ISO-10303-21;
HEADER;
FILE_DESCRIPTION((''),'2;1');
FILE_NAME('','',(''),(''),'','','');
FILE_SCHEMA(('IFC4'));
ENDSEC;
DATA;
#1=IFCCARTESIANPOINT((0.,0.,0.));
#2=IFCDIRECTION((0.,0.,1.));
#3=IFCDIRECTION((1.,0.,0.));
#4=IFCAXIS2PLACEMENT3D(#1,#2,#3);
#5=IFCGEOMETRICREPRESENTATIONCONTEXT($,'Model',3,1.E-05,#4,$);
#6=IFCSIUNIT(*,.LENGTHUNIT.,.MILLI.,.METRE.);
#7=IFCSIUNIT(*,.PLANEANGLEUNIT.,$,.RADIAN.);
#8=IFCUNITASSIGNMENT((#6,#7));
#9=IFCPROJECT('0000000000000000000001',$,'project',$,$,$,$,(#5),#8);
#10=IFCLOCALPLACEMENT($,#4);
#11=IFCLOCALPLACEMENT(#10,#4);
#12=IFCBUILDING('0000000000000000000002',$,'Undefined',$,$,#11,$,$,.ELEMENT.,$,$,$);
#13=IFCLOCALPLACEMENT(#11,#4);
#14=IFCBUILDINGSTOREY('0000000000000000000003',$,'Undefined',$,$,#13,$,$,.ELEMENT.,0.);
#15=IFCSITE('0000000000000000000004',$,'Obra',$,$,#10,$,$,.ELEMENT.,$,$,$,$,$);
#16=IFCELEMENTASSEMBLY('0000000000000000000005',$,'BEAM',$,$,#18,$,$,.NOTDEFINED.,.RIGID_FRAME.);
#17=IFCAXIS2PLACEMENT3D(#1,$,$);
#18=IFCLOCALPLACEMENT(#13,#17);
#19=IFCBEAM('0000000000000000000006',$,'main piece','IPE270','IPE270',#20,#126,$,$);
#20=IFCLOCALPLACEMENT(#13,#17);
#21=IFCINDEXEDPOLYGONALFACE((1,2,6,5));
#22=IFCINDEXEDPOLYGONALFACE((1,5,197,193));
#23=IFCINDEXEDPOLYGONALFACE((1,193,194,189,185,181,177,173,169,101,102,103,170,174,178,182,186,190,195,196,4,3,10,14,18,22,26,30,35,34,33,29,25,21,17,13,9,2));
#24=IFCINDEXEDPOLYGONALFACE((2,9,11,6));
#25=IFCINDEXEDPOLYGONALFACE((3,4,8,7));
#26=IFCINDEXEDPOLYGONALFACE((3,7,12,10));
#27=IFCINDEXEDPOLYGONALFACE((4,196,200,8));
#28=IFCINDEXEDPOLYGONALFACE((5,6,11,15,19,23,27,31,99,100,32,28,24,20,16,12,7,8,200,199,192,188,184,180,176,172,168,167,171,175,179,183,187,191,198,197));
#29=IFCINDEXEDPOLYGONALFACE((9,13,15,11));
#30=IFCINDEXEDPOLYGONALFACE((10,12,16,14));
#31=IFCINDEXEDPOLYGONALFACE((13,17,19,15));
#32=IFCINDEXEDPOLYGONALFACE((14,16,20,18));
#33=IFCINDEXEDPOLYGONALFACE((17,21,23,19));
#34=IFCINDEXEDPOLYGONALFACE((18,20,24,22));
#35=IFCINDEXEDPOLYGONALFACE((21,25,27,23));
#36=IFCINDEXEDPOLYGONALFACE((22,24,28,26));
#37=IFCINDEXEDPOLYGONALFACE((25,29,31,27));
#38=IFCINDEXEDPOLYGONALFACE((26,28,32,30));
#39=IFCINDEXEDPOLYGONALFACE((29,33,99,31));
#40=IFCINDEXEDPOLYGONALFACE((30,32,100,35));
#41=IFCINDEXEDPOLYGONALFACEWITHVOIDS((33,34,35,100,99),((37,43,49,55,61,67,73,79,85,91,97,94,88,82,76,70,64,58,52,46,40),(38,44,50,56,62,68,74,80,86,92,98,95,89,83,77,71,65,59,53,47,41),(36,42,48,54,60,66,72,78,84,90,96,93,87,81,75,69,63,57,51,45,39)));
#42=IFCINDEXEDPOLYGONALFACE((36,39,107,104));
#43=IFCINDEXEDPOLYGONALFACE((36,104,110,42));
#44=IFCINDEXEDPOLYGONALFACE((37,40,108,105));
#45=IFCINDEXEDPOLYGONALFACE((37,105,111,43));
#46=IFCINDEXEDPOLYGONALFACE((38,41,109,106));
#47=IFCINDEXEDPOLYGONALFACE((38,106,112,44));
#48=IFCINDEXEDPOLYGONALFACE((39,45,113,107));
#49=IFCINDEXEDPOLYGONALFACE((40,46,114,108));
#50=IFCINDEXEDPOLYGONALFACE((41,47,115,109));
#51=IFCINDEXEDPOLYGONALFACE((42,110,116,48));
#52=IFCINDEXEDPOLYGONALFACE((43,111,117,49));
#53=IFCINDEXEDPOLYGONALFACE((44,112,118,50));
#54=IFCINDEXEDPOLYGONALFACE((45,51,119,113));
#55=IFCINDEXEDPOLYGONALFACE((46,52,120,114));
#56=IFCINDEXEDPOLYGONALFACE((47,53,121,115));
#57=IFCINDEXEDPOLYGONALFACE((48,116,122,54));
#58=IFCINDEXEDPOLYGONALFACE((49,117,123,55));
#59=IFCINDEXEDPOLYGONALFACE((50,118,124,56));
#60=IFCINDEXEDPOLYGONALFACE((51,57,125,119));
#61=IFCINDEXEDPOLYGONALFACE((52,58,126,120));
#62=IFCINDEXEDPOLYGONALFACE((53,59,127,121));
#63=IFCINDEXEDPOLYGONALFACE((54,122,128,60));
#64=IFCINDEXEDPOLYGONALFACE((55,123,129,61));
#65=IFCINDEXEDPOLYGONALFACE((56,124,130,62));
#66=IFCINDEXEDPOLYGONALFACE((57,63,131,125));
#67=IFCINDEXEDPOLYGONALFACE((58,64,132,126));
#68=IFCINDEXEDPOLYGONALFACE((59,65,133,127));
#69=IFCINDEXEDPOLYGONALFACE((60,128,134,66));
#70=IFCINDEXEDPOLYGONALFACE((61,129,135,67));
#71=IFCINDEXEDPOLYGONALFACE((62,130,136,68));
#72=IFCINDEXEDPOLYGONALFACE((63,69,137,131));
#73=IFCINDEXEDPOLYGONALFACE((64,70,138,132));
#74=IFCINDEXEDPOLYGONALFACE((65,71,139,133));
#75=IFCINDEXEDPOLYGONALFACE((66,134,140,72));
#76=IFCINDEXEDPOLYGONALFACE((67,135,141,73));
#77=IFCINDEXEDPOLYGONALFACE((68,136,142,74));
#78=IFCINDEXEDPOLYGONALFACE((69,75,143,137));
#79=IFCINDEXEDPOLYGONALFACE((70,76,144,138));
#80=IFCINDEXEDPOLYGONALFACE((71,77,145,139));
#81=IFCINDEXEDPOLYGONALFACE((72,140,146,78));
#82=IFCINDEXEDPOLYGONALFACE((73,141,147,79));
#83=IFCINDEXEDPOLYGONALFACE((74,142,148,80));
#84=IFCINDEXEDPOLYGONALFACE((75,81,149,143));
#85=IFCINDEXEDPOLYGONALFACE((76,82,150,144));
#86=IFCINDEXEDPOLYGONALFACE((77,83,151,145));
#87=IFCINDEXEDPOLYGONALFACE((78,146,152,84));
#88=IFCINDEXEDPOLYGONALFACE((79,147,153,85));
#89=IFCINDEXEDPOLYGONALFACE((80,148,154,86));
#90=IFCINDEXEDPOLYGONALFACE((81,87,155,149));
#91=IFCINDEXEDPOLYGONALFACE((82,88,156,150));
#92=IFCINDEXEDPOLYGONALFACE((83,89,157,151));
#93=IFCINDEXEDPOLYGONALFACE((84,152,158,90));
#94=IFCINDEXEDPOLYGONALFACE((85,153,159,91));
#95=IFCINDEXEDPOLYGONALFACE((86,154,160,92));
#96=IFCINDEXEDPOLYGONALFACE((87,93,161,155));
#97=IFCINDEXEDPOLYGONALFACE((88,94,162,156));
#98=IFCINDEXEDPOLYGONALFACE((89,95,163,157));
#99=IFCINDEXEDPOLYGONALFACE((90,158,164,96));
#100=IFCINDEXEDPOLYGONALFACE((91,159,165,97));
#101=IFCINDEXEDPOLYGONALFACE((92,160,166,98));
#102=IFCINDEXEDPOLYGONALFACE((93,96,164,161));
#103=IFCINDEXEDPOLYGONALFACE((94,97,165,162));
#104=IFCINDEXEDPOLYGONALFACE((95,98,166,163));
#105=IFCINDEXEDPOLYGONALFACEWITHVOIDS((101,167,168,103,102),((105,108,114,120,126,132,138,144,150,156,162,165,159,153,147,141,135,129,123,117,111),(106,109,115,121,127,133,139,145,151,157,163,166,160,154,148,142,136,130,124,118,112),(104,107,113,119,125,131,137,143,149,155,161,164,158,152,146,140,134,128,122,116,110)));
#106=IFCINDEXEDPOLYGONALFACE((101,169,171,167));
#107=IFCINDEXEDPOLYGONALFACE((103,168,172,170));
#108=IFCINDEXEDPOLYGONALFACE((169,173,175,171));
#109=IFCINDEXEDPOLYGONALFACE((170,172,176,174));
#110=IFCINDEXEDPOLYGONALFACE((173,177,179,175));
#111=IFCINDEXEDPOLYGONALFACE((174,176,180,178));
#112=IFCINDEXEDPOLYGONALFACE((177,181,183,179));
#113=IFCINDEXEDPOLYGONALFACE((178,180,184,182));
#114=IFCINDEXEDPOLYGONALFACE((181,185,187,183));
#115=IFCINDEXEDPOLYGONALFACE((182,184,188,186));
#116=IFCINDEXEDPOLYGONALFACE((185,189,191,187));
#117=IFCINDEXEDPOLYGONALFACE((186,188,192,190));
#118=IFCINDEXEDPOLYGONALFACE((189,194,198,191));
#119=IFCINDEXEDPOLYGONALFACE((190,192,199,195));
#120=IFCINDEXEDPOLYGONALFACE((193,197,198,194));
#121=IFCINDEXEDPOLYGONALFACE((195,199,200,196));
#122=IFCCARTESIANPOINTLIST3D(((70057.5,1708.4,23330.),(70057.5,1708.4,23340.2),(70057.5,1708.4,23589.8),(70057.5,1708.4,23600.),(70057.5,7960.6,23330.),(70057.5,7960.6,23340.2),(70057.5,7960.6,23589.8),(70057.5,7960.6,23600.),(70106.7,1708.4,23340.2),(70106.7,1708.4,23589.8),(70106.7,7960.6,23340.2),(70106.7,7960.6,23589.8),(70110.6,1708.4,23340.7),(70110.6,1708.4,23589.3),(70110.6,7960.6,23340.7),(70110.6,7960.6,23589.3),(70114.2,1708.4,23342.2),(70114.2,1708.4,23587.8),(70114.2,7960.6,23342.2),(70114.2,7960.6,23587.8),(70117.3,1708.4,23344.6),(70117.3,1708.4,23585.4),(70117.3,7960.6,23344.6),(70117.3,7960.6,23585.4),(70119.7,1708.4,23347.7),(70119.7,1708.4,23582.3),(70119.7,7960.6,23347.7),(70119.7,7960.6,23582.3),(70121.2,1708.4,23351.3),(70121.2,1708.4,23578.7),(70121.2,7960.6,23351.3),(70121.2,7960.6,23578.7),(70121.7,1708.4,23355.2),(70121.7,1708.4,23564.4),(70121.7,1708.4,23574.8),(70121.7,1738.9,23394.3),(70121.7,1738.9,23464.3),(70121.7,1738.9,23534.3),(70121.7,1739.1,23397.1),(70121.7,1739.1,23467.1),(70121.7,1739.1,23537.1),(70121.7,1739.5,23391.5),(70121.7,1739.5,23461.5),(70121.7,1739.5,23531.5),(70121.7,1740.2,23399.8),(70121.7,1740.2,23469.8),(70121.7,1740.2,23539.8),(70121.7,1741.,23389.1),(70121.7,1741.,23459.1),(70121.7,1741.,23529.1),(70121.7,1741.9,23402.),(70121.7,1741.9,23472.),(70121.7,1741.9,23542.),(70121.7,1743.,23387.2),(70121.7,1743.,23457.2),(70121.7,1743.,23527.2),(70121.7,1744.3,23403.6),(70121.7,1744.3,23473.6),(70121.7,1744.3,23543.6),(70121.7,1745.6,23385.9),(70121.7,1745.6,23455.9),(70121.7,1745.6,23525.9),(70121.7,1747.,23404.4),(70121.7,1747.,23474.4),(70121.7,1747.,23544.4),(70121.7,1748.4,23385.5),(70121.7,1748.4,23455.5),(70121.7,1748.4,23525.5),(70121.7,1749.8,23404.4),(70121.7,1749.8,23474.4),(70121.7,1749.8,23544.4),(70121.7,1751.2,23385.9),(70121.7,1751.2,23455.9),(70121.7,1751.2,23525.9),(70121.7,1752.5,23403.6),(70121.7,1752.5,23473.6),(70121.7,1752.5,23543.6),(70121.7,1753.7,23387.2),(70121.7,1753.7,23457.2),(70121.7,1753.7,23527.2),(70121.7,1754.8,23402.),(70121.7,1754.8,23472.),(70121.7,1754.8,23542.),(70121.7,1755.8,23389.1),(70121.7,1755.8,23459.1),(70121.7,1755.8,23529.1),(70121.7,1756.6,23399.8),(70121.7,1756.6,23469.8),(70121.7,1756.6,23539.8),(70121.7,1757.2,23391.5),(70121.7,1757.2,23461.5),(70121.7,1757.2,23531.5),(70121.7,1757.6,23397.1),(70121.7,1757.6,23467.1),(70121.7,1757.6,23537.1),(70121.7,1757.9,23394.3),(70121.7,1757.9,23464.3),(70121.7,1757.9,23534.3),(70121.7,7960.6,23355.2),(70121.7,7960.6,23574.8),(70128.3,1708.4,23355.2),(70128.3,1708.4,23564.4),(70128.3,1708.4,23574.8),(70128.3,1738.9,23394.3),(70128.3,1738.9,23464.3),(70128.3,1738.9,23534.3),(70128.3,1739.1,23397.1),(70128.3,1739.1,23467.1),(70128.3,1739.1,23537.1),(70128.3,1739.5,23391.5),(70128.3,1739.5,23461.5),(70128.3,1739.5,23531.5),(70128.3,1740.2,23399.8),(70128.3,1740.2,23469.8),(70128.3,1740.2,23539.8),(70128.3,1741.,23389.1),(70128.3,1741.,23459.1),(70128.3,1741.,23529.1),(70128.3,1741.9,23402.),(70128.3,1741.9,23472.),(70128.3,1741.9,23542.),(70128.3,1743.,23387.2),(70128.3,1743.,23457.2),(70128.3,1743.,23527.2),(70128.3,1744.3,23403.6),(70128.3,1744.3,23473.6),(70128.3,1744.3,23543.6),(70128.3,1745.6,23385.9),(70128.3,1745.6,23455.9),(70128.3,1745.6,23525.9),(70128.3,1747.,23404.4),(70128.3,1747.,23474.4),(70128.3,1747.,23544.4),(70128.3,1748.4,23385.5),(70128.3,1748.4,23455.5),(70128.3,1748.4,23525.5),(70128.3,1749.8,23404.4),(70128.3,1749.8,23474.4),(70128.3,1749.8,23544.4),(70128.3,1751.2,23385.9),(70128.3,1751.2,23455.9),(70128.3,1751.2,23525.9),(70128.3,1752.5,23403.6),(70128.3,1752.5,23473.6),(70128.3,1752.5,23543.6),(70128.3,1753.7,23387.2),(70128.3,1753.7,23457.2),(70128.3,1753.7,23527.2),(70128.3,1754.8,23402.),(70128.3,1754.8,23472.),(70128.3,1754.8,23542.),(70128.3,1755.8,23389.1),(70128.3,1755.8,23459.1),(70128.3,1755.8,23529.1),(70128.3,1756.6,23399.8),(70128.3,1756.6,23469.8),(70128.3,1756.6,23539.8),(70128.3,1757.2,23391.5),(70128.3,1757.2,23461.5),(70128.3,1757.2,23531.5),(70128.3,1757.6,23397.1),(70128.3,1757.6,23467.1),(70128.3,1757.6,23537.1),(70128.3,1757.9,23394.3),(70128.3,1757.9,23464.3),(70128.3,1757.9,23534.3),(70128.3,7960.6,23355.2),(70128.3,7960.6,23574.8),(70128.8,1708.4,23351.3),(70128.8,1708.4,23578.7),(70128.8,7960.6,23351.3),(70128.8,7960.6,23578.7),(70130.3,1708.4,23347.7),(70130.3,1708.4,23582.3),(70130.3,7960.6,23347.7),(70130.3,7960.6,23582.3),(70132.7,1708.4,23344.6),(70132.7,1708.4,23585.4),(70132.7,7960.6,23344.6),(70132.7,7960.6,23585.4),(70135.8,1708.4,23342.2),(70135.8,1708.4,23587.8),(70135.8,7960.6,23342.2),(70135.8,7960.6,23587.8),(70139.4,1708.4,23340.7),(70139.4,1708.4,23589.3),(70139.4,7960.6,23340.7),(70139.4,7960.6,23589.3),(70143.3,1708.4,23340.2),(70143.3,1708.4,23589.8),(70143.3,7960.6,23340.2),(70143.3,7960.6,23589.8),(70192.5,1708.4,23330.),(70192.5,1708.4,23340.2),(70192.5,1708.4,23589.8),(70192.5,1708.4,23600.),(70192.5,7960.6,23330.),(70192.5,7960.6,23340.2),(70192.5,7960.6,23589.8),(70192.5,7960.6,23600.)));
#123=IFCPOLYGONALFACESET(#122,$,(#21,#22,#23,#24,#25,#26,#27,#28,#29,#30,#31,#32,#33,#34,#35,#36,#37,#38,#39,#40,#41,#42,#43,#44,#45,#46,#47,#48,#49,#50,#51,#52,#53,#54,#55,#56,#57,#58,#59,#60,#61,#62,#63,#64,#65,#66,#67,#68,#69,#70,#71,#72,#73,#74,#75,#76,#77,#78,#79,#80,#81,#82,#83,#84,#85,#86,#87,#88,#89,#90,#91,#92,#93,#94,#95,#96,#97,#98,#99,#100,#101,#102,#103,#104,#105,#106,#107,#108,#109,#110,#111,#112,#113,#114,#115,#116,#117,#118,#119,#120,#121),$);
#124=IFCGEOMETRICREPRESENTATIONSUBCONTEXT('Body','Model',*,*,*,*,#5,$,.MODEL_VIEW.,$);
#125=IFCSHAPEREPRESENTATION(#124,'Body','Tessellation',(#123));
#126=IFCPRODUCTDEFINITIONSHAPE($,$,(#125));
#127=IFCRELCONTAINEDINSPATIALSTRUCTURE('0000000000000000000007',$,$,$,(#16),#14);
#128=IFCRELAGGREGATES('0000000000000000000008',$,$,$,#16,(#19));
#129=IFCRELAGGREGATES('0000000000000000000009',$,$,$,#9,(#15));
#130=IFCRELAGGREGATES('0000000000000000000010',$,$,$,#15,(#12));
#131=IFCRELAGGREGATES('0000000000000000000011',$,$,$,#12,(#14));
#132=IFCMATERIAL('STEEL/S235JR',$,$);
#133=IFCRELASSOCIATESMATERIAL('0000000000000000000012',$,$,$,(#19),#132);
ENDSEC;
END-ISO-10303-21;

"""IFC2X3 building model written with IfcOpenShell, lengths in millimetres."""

from ifc_helpers import new_model, si_unit, frame, origin_with_axes, origin_2d_with_axis, place, context, subcontext, project, spatial, rectangle, circle, i_section, extrude, clip, halfspace, source, transform, mapped, material, element, aggregate, save


model = new_model("IFC2X3")

# Units and contexts
model_context = context("Model", 3, precision=1e-05, world=origin_with_axes())
body_context = subcontext(model_context, "Body", "Model", "MODEL_VIEW")
ifc_project = project(units=[si_unit("LENGTHUNIT", "METRE", prefix="MILLI"), si_unit("PLANEANGLEUNIT", "RADIAN")], contexts=[model_context])

# Site, building, storey
site_placement = place(None, origin_with_axes())
site = spatial("IfcSite", under=ifc_project, at=site_placement, Name="Obra", CompositionType="ELEMENT")
building_placement = place(site_placement, origin_with_axes())
building = spatial("IfcBuilding", under=site, at=building_placement, Name="Undefined", CompositionType="ELEMENT")
storey_placement = place(building_placement, origin_with_axes())
storey = spatial("IfcBuildingStorey", under=building, at=storey_placement, Name="Undefined", CompositionType="ELEMENT", Elevation=0.0)

# Element assembly, beam, openings
ifc_material_1 = material(Name="STEEL/S235JR")
shared_shape_1 = source(origin_with_axes(), body_context, "Body", "SweptSolid", [
    extrude(circle(Radius=9.5, at=origin_2d_with_axis()), frame((0.0, -3.4, 0.0), z_axis=(0.0, 1.0, 0.0), x_axis=(1.0, 0.0, 0.0)), (0.0, 0.0, 1.0), 6.8),
])
assembly_1_placement = place(storey_placement, origin_with_axes())
assembly_1 = element("IfcElementAssembly", 1, at=assembly_1_placement, inside=storey, Name="BEAM", AssemblyPlace="NOTDEFINED", PredefinedType="RIGID_FRAME")
beam_1_placement = place(assembly_1_placement, frame((70125.0, 1711.1, 23465.0), z_axis=(0.0, 0.0, 1.0), x_axis=(0.0, 1.0, 0.0)))
beam_1 = element("IfcBeam", 2, at=beam_1_placement, material=ifc_material_1, Name="main piece", Description="IPE270", ObjectType="IPE270", context=body_context, shape_type="Clipping", body=[
    clip(clip(extrude(i_section(OverallWidth=135.0, OverallDepth=270.0, WebThickness=6.6, FlangeThickness=10.2, FilletRadius=15.0, at=origin_2d_with_axis()), frame((6296.4, 0.0, 0.0), z_axis=(-1.0, 0.0, 0.0), x_axis=(0.0, -1.0, 0.0)), (0.0, 0.0, 1.0), 6299.1), halfspace(frame((6249.5, -60.0, -120.0), z_axis=(1.0, 0.0, 0.0), x_axis=(0.0, 0.0, 1.0)), False)), halfspace(frame((-2.7, 0.0, -235.0), z_axis=(1.0, 0.0, 0.0), x_axis=(0.0, -1.0, 0.0)), True)),
])
opening_1_placement = place(assembly_1_placement, frame((70125.0, 1711.1, 23465.0), z_axis=(0.0, 0.0, 1.0), x_axis=(0.0, 1.0, 0.0)))
element("IfcOpeningElement", 3, at=opening_1_placement, cuts=beam_1, ObjectType="Recess", context=body_context, shape_type="SweptSolid", body=[
    extrude(rectangle(XDim=36.6, YDim=102.3, at=origin_2d_with_axis()), frame((-53.9, -68.5, 117.7), z_axis=(0.0, 1.0, 0.0), x_axis=(0.0, 0.0, -1.0)), (0.0, 0.0, 1.0), 137.0),
])
opening_2_placement = place(assembly_1_placement, frame((70125.0, 1708.4, 23570.0), z_axis=(0.0, 1.0, 0.0), x_axis=(0.0, 0.0, -1.0)))
element("IfcOpeningElement", 4, at=opening_2_placement, cuts=beam_1, ObjectType="Opening", context=body_context, shape_type="MappedRepresentation", body=[
    mapped(shared_shape_1, transform((35.0, 0.0, 40.0))),
    mapped(shared_shape_1, transform((105.0, 0.0, 40.0))),
    mapped(shared_shape_1, transform((175.0, 0.0, 40.0))),
])

aggregate(assembly_1, [beam_1])

save(model, "model.ifc")
